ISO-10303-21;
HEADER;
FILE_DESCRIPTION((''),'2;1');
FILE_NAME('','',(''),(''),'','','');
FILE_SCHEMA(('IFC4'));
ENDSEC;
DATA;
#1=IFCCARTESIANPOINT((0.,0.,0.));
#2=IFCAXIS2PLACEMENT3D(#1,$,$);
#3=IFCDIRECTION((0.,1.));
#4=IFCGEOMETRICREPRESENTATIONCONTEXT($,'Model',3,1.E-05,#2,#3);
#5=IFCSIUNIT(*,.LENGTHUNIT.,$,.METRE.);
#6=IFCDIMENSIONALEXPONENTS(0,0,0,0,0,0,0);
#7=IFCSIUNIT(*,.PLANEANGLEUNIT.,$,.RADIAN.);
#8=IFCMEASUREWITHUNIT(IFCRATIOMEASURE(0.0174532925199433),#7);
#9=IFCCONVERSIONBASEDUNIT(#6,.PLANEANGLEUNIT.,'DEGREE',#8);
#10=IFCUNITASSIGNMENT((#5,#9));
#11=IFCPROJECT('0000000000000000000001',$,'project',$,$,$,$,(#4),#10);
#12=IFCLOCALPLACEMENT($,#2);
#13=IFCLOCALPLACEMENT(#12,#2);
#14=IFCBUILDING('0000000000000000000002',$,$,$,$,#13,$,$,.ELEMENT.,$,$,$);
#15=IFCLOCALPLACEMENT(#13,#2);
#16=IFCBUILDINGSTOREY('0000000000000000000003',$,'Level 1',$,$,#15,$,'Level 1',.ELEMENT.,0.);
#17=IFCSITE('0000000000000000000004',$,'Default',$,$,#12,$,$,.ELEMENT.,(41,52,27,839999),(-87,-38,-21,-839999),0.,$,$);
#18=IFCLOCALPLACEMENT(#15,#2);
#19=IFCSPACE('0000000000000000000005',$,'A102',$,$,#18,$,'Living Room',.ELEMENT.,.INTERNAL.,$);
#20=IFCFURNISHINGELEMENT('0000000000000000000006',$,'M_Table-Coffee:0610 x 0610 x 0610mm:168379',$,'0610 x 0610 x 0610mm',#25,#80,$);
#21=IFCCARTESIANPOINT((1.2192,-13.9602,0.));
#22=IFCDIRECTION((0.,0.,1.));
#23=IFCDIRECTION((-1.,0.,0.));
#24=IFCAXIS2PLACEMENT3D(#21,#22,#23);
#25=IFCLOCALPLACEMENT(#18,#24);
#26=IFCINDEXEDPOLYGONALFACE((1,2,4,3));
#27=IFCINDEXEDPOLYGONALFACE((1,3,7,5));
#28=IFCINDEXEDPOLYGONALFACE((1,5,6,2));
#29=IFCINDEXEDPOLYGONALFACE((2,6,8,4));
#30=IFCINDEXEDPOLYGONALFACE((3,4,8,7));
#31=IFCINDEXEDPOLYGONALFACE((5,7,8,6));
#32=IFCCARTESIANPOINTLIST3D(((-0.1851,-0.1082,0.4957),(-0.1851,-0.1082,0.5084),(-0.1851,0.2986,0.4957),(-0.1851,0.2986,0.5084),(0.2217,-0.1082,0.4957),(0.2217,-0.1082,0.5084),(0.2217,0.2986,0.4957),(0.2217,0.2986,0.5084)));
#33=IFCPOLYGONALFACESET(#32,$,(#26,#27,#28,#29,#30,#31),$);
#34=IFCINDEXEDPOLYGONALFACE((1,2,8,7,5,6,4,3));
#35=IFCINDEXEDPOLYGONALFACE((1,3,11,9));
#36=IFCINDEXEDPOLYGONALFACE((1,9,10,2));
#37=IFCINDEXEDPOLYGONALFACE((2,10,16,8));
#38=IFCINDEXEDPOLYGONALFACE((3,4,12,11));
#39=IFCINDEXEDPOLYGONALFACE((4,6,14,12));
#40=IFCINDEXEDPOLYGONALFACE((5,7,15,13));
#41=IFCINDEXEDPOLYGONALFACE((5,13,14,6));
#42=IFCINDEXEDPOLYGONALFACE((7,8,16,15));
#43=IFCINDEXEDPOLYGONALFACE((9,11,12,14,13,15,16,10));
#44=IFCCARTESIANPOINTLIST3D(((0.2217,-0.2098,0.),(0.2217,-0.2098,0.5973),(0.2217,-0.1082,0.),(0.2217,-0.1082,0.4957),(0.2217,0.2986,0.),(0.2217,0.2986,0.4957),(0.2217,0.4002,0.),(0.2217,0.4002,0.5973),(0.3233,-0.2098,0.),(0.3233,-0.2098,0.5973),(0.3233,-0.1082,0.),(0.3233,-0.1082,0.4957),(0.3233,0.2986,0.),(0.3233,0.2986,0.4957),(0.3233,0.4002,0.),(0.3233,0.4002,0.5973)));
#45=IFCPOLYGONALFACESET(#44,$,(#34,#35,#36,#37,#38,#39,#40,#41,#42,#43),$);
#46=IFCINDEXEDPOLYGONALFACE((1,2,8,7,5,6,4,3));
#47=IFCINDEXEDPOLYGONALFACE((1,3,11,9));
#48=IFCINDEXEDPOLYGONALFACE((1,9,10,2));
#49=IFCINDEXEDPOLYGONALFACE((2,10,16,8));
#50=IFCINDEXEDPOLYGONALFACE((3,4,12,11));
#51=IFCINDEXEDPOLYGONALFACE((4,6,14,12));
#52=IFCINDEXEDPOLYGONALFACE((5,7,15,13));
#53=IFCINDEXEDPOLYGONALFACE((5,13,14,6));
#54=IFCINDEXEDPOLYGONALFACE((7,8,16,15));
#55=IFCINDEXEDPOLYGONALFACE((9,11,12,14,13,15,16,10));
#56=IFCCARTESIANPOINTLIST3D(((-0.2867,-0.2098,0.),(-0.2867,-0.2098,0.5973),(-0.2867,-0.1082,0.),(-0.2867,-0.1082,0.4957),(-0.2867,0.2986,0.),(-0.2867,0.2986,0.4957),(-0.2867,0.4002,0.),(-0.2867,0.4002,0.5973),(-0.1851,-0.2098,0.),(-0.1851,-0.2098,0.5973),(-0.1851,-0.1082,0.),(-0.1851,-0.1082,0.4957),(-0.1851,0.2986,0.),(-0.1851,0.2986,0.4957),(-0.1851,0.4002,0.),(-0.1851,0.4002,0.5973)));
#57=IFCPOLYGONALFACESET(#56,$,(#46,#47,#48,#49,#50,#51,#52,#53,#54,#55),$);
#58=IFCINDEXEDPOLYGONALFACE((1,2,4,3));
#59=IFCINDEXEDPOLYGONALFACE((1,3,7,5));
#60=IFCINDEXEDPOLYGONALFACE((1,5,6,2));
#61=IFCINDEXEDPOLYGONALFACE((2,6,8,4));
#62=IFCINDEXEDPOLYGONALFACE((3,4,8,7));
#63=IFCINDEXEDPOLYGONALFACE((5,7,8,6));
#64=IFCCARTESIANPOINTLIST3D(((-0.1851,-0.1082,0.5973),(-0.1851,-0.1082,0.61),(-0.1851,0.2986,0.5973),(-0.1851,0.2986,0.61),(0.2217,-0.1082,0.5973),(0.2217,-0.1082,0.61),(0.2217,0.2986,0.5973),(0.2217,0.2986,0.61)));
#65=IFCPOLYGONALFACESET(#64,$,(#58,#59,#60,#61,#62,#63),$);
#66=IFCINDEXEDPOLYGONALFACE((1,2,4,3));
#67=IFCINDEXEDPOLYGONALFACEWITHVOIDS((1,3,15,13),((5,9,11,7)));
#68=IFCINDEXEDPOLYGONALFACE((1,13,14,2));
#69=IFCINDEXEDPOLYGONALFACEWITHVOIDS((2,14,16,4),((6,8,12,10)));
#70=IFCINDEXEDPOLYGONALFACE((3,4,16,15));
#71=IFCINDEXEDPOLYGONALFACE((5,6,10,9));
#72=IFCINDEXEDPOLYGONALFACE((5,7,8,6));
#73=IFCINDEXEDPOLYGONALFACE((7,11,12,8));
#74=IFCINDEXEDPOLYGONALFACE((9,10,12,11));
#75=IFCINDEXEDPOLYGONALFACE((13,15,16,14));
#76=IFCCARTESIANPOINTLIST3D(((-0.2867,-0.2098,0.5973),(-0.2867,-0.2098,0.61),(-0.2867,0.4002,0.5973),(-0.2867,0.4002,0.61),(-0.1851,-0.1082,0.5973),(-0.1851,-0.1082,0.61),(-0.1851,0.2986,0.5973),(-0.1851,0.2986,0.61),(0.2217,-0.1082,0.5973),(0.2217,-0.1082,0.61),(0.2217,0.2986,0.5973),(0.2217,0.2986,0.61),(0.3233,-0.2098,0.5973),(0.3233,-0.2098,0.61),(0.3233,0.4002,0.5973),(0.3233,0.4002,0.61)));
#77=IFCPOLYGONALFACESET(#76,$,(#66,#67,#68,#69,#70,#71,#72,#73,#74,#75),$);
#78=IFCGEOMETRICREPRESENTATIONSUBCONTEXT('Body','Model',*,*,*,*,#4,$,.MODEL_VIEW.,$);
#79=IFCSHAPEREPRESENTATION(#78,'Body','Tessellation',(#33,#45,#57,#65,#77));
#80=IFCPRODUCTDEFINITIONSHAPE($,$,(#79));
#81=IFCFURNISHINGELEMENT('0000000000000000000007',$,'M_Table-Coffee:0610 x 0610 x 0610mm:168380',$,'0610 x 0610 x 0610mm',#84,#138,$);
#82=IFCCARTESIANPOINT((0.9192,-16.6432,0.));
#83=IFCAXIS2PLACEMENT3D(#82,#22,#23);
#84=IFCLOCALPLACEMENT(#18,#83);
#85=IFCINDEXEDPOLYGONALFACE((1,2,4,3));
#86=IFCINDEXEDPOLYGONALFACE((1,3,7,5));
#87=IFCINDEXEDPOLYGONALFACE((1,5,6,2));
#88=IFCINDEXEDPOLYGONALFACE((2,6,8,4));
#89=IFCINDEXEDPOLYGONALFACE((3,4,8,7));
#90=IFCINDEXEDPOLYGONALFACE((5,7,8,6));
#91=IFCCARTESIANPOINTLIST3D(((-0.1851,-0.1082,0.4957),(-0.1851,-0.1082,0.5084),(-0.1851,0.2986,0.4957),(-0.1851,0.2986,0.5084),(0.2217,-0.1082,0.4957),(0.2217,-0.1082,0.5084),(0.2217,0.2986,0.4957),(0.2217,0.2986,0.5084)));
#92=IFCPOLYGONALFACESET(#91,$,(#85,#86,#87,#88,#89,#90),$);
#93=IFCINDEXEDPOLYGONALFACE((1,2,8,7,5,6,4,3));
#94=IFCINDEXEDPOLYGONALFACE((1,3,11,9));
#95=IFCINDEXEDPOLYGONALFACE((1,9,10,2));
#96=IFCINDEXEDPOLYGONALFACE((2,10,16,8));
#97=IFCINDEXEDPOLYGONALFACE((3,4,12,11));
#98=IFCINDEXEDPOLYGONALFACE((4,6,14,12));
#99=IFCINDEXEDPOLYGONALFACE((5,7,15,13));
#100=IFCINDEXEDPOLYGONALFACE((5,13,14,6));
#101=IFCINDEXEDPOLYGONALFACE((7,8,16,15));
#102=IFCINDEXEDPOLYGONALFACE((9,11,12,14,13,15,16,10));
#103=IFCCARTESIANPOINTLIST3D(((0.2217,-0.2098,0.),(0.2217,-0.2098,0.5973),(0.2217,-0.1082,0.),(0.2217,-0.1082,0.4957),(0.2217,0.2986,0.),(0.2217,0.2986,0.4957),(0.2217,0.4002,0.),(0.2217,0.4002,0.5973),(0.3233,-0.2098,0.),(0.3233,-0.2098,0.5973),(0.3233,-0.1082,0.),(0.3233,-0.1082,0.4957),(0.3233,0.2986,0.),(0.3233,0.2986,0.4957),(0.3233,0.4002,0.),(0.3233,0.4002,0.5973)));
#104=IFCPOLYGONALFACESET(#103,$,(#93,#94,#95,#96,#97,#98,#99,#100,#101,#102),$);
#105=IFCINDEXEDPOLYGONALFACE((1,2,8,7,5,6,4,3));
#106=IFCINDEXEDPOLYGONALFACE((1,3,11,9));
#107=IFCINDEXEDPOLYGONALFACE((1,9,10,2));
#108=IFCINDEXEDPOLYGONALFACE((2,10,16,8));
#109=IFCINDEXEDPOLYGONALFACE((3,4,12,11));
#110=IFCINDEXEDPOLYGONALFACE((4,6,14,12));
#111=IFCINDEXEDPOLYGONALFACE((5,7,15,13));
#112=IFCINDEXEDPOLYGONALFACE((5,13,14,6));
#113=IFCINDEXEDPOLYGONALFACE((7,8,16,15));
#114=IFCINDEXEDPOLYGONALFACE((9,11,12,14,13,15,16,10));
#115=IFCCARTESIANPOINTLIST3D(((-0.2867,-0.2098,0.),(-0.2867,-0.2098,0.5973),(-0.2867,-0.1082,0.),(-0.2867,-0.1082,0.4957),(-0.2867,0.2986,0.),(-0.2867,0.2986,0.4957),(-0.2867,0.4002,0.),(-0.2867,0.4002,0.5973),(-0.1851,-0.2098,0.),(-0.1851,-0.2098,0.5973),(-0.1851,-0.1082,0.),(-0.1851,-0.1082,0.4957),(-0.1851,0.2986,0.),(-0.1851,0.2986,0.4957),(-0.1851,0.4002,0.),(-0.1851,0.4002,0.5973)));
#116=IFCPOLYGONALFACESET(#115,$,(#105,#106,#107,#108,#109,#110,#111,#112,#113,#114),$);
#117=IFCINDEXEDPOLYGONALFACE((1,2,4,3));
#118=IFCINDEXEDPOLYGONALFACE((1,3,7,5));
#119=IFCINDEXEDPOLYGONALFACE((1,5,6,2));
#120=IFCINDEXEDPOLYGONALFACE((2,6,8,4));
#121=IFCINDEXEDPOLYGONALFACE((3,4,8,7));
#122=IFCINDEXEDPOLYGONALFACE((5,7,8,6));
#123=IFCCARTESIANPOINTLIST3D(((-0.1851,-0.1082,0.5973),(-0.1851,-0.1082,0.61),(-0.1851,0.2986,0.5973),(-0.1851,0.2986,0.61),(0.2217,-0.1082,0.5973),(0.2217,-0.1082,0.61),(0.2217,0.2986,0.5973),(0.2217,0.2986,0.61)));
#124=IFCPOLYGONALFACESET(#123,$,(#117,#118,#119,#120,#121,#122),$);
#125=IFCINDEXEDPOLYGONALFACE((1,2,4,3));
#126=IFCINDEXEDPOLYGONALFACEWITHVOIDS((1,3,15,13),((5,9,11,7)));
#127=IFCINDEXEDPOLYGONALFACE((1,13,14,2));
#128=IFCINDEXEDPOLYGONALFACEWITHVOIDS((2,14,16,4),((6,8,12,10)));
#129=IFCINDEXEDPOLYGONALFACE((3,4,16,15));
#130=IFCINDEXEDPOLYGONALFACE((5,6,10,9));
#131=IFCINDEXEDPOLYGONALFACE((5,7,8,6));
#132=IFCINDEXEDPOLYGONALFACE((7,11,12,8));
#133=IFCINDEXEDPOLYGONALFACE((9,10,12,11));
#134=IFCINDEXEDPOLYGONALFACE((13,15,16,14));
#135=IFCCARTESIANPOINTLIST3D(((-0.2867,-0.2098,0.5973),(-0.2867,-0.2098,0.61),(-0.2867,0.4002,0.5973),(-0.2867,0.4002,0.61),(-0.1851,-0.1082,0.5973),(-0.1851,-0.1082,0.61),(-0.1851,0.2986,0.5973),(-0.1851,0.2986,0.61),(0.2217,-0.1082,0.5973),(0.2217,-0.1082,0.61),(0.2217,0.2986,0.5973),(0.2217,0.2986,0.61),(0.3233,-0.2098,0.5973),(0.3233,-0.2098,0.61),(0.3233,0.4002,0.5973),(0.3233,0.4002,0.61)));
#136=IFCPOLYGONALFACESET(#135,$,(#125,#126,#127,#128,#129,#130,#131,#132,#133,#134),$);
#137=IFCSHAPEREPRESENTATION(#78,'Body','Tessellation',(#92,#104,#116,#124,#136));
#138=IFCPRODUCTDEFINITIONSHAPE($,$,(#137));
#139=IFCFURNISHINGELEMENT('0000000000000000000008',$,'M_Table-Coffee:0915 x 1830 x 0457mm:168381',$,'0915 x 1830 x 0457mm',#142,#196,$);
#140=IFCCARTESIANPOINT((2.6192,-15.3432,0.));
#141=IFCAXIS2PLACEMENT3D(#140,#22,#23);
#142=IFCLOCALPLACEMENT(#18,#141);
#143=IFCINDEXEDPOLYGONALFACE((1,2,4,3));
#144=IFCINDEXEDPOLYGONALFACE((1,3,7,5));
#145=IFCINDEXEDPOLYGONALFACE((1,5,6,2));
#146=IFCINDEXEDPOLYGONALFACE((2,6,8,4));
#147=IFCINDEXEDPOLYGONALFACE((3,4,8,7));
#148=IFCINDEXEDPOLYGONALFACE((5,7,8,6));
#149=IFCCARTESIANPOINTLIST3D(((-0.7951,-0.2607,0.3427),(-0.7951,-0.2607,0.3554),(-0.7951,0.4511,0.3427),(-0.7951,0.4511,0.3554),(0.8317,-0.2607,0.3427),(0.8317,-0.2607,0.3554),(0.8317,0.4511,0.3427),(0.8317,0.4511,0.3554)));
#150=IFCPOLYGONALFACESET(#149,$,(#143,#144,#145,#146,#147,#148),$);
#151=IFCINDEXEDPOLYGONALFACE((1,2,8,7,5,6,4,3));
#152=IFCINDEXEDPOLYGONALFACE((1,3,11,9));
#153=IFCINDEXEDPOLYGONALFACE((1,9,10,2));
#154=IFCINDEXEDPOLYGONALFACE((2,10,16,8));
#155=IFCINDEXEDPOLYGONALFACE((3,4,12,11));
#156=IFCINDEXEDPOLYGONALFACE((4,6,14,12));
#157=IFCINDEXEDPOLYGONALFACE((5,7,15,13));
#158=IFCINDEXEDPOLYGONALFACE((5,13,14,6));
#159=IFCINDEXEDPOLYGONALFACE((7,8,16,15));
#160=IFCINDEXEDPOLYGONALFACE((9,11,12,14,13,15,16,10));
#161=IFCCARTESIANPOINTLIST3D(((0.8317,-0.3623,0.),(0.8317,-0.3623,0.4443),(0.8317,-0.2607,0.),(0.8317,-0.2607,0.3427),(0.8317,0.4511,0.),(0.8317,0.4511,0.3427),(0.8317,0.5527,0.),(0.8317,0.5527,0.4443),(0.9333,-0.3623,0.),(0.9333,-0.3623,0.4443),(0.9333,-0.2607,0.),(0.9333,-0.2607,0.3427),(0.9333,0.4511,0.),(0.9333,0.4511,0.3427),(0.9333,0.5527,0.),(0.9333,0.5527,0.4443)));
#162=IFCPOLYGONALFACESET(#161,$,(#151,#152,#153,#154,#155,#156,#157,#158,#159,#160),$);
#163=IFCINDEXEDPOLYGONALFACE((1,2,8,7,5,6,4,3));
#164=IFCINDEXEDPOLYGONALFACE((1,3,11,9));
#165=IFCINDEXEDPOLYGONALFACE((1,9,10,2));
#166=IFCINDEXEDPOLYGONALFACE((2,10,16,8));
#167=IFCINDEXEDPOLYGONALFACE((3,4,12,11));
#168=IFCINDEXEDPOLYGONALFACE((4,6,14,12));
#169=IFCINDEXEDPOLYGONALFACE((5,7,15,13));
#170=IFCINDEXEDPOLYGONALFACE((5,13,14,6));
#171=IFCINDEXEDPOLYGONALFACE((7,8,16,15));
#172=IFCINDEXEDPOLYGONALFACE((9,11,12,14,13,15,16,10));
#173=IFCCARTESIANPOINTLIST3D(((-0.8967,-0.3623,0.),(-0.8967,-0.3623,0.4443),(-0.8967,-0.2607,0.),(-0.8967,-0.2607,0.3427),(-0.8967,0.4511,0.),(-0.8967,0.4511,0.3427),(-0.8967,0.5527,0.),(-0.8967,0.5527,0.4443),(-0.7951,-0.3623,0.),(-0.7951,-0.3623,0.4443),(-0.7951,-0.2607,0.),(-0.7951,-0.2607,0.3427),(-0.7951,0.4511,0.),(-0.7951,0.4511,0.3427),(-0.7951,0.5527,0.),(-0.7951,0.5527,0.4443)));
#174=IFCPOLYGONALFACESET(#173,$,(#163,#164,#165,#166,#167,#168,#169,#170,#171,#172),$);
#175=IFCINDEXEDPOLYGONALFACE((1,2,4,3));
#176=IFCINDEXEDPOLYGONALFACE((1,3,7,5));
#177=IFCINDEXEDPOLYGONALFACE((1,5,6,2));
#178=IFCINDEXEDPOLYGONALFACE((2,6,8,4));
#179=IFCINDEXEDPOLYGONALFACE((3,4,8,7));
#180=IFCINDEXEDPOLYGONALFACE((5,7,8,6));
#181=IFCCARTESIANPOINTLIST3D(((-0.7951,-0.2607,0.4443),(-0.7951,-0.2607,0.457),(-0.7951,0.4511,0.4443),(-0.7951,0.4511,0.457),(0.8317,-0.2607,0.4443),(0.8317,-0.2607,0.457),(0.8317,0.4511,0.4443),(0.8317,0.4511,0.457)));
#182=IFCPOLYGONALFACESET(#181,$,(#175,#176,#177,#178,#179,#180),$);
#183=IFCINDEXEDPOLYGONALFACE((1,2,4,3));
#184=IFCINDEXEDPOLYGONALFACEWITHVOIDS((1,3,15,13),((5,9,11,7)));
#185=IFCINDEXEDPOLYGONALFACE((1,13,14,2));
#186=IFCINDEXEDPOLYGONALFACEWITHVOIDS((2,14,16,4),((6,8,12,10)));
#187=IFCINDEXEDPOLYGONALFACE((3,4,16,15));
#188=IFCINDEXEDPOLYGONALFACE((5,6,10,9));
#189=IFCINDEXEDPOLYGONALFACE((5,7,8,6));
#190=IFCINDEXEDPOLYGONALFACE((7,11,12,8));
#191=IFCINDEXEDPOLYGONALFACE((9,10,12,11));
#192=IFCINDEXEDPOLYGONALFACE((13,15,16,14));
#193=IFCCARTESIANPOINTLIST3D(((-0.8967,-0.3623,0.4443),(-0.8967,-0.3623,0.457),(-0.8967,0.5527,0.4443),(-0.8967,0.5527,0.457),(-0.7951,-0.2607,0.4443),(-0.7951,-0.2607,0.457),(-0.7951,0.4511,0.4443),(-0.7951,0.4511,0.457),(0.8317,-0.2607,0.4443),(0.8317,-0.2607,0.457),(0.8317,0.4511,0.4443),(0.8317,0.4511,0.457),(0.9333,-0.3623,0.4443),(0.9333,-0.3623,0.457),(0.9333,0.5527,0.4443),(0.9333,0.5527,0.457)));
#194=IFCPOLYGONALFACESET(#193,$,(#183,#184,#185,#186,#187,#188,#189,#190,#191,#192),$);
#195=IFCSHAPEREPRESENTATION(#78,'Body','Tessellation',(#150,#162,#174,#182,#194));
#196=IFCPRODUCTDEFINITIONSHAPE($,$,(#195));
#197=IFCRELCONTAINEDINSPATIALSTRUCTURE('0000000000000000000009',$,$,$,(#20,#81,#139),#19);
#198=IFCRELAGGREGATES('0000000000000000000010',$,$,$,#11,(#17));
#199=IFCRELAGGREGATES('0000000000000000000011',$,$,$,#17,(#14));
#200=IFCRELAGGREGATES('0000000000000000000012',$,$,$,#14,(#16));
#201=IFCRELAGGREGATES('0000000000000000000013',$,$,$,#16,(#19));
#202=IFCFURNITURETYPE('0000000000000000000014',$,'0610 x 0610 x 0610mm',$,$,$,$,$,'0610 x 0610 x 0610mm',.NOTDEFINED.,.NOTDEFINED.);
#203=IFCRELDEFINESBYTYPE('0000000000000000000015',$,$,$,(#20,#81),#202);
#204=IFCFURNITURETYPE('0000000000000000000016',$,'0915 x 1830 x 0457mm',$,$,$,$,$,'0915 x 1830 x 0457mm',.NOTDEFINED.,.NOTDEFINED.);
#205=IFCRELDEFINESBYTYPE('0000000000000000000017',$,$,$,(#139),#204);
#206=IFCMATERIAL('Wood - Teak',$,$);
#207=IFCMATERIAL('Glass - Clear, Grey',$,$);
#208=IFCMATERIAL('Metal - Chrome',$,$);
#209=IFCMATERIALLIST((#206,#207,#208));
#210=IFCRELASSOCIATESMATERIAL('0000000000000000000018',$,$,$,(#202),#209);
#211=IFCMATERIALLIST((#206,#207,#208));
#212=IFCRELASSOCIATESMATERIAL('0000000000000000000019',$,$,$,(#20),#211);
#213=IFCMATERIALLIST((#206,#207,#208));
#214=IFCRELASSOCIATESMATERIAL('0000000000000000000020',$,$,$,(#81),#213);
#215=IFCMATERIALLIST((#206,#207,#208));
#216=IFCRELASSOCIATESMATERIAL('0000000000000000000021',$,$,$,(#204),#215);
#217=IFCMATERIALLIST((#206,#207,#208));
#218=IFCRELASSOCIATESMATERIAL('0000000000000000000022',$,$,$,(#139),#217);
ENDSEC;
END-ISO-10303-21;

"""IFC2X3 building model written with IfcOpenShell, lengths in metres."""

from ifc_helpers import new_model, entity, si_unit, converted_unit, direction, frame, origin, origin_2d_with_axis, place, context, subcontext, project, spatial, polyline, rectangle, outline, extrude, source, transform, mapped, material, material_list, type_object, type_shapes, element, save


model = new_model("IFC2X3")

# Units and contexts
model_context = context("Model", 3, precision=1e-05, world=origin(), true_north=direction((0.0, 1.0)))
body_context = subcontext(model_context, "Body", "Model", "MODEL_VIEW")
ifc_project = project(units=[si_unit("LENGTHUNIT", "METRE"), converted_unit("PLANEANGLEUNIT", "DEGREE", entity("IfcRatioMeasure", 0.0174532925199433), si_unit("PLANEANGLEUNIT", "RADIAN"), dimensions=[0, 0, 0, 0, 0, 0, 0])], contexts=[model_context])

# Site, building, storey
site_placement = place(None, origin())
site = spatial("IfcSite", under=ifc_project, at=site_placement, Name="Default", CompositionType="ELEMENT", RefLatitude=(41, 52, 27, 839999), RefLongitude=(-87, -38, -21, -839999), RefElevation=0.0)
building_placement = place(site_placement, origin())
building = spatial("IfcBuilding", under=site, at=building_placement, CompositionType="ELEMENT")
storey_placement = place(building_placement, origin())
storey = spatial("IfcBuildingStorey", under=building, at=storey_placement, Name="Level 1", LongName="Level 1", CompositionType="ELEMENT", Elevation=0.0)

# Shared definitions
space_1_placement = place(storey_placement, origin())
space_1 = spatial("IfcSpace", under=storey, at=space_1_placement, Name="A102", LongName="Living Room", CompositionType="ELEMENT", InteriorOrExteriorSpace="INTERNAL")

# Furnishing elements
ifc_material_1 = material(Name="Wood - Teak")
ifc_material_2 = material(Name="Glass - Clear, Grey")
ifc_material_3 = material(Name="Metal - Chrome")
ifc_material_list_1 = material_list([ifc_material_1, ifc_material_2, ifc_material_3])
ifc_material_list_2 = material_list([ifc_material_1, ifc_material_2, ifc_material_3])
furniture_type_1 = type_object("IfcFurnitureType", Name="0610 x 0610 x 0610mm", ElementType="0610 x 0610 x 0610mm", AssemblyPlace="NOTDEFINED", material=ifc_material_list_2)
shared_shape_1 = source(origin(), body_context, "Body", "SweptSolid", [
    extrude(rectangle(XDim=0.4068, YDim=0.4068, at=origin_2d_with_axis()), frame((0.0183, 0.0952, 0.4957), z_axis=(0.0, 0.0, 1.0), x_axis=(-1.0, 0.0, 0.0)), (0.0, 0.0, 1.0), 0.0127),
    extrude(outline(polyline([(-0.2732, -0.305), (0.324, -0.305), (0.324, 0.305), (-0.2732, 0.305), (-0.2732, 0.2034), (0.2225, 0.2034), (0.2225, -0.2034), (-0.2732, -0.2034), (-0.2732, -0.305)])), frame((0.2217, 0.0952, 0.2732), z_axis=(1.0, 0.0, 0.0), x_axis=(0.0, 0.0, 1.0)), (0.0, 0.0, 1.0), 0.1016),
    extrude(outline(polyline([(-0.305, -0.3241), (0.305, -0.3241), (0.305, 0.2733), (0.2034, 0.2733), (0.2034, -0.2224), (-0.2034, -0.2224), (-0.2034, 0.2733), (-0.305, 0.2733), (-0.305, -0.3241)])), frame((-0.2867, 0.0952, 0.2733), z_axis=(1.0, 0.0, 0.0), x_axis=(0.0, -1.0, 0.0)), (0.0, 0.0, 1.0), 0.1016),
    extrude(rectangle(XDim=0.4068, YDim=0.4068, at=origin_2d_with_axis()), frame((0.0183, 0.0952, 0.5973), z_axis=(0.0, 0.0, 1.0), x_axis=(-1.0, 0.0, 0.0)), (0.0, 0.0, 1.0), 0.0127),
    extrude(outline(polyline([(-0.305, -0.305), (0.305, -0.305), (0.305, 0.305), (-0.305, 0.305), (-0.305, -0.305)]), holes=[polyline([(-0.2034, -0.2034), (-0.2034, 0.2034), (0.2034, 0.2034), (0.2034, -0.2034), (-0.2034, -0.2034)])]), frame((0.0183, 0.0952, 0.5973), z_axis=(0.0, 0.0, 1.0), x_axis=(-1.0, 0.0, 0.0)), (0.0, 0.0, 1.0), 0.0127),
])
type_shapes(furniture_type_1, [shared_shape_1])
furnishing_1_placement = place(space_1_placement, frame((1.2192, -13.9602, 0.0), z_axis=(0.0, 0.0, 1.0), x_axis=(-1.0, 0.0, 0.0)))
element("IfcFurnishingElement", 1, at=furnishing_1_placement, inside=space_1, type_object=furniture_type_1, material=ifc_material_list_1, Name="M_Table-Coffee:0610 x 0610 x 0610mm:168379", ObjectType="0610 x 0610 x 0610mm", context=body_context, shape_type="MappedRepresentation", body=[
    mapped(shared_shape_1, transform((0.0, 0.0, 0.0), scale=1.0)),
])
ifc_material_list_3 = material_list([ifc_material_1, ifc_material_2, ifc_material_3])
furnishing_2_placement = place(space_1_placement, frame((0.9192, -16.6432, 0.0), z_axis=(0.0, 0.0, 1.0), x_axis=(-1.0, 0.0, 0.0)))
element("IfcFurnishingElement", 2, at=furnishing_2_placement, inside=space_1, type_object=furniture_type_1, material=ifc_material_list_3, Name="M_Table-Coffee:0610 x 0610 x 0610mm:168380", ObjectType="0610 x 0610 x 0610mm", context=body_context, shape_type="MappedRepresentation", body=[
    mapped(shared_shape_1, transform((0.0, 0.0, 0.0), scale=1.0)),
])
ifc_material_list_4 = material_list([ifc_material_1, ifc_material_2, ifc_material_3])
ifc_material_list_5 = material_list([ifc_material_1, ifc_material_2, ifc_material_3])
furniture_type_2 = type_object("IfcFurnitureType", Name="0915 x 1830 x 0457mm", ElementType="0915 x 1830 x 0457mm", AssemblyPlace="NOTDEFINED", material=ifc_material_list_5)
shared_shape_2 = source(origin(), body_context, "Body", "SweptSolid", [
    extrude(rectangle(XDim=1.6268, YDim=0.7118, at=origin_2d_with_axis()), frame((0.0183, 0.0952, 0.3427), z_axis=(0.0, 0.0, 1.0), x_axis=(-1.0, 0.0, 0.0)), (0.0, 0.0, 1.0), 0.0127),
    extrude(outline(polyline([(-0.1967, -0.4575), (0.2475, -0.4575), (0.2475, 0.4575), (-0.1967, 0.4575), (-0.1967, 0.3559), (0.146, 0.3559), (0.146, -0.3559), (-0.1967, -0.3559), (-0.1967, -0.4575)])), frame((0.8317, 0.0952, 0.1967), z_axis=(1.0, 0.0, 0.0), x_axis=(0.0, 0.0, 1.0)), (0.0, 0.0, 1.0), 0.1016),
    extrude(outline(polyline([(-0.4575, -0.2476), (0.4575, -0.2476), (0.4575, 0.1968), (0.3559, 0.1968), (0.3559, -0.1459), (-0.3559, -0.1459), (-0.3559, 0.1968), (-0.4575, 0.1968), (-0.4575, -0.2476)])), frame((-0.8967, 0.0952, 0.1968), z_axis=(1.0, 0.0, 0.0), x_axis=(0.0, -1.0, 0.0)), (0.0, 0.0, 1.0), 0.1016),
    extrude(rectangle(XDim=1.6268, YDim=0.7118, at=origin_2d_with_axis()), frame((0.0183, 0.0952, 0.4443), z_axis=(0.0, 0.0, 1.0), x_axis=(-1.0, 0.0, 0.0)), (0.0, 0.0, 1.0), 0.0127),
    extrude(outline(polyline([(-0.915, -0.4575), (0.915, -0.4575), (0.915, 0.4575), (-0.915, 0.4575), (-0.915, -0.4575)]), holes=[polyline([(-0.8134, -0.3559), (-0.8134, 0.3559), (0.8134, 0.3559), (0.8134, -0.3559), (-0.8134, -0.3559)])]), frame((0.0183, 0.0952, 0.4443), z_axis=(0.0, 0.0, 1.0), x_axis=(-1.0, 0.0, 0.0)), (0.0, 0.0, 1.0), 0.0127),
])
type_shapes(furniture_type_2, [shared_shape_2])
furnishing_3_placement = place(space_1_placement, frame((2.6192, -15.3432, 0.0), z_axis=(0.0, 0.0, 1.0), x_axis=(-1.0, 0.0, 0.0)))
element("IfcFurnishingElement", 3, at=furnishing_3_placement, inside=space_1, type_object=furniture_type_2, material=ifc_material_list_4, Name="M_Table-Coffee:0915 x 1830 x 0457mm:168381", ObjectType="0915 x 1830 x 0457mm", context=body_context, shape_type="MappedRepresentation", body=[
    mapped(shared_shape_2, transform((0.0, 0.0, 0.0), scale=1.0)),
])

save(model, "model.ifc")
